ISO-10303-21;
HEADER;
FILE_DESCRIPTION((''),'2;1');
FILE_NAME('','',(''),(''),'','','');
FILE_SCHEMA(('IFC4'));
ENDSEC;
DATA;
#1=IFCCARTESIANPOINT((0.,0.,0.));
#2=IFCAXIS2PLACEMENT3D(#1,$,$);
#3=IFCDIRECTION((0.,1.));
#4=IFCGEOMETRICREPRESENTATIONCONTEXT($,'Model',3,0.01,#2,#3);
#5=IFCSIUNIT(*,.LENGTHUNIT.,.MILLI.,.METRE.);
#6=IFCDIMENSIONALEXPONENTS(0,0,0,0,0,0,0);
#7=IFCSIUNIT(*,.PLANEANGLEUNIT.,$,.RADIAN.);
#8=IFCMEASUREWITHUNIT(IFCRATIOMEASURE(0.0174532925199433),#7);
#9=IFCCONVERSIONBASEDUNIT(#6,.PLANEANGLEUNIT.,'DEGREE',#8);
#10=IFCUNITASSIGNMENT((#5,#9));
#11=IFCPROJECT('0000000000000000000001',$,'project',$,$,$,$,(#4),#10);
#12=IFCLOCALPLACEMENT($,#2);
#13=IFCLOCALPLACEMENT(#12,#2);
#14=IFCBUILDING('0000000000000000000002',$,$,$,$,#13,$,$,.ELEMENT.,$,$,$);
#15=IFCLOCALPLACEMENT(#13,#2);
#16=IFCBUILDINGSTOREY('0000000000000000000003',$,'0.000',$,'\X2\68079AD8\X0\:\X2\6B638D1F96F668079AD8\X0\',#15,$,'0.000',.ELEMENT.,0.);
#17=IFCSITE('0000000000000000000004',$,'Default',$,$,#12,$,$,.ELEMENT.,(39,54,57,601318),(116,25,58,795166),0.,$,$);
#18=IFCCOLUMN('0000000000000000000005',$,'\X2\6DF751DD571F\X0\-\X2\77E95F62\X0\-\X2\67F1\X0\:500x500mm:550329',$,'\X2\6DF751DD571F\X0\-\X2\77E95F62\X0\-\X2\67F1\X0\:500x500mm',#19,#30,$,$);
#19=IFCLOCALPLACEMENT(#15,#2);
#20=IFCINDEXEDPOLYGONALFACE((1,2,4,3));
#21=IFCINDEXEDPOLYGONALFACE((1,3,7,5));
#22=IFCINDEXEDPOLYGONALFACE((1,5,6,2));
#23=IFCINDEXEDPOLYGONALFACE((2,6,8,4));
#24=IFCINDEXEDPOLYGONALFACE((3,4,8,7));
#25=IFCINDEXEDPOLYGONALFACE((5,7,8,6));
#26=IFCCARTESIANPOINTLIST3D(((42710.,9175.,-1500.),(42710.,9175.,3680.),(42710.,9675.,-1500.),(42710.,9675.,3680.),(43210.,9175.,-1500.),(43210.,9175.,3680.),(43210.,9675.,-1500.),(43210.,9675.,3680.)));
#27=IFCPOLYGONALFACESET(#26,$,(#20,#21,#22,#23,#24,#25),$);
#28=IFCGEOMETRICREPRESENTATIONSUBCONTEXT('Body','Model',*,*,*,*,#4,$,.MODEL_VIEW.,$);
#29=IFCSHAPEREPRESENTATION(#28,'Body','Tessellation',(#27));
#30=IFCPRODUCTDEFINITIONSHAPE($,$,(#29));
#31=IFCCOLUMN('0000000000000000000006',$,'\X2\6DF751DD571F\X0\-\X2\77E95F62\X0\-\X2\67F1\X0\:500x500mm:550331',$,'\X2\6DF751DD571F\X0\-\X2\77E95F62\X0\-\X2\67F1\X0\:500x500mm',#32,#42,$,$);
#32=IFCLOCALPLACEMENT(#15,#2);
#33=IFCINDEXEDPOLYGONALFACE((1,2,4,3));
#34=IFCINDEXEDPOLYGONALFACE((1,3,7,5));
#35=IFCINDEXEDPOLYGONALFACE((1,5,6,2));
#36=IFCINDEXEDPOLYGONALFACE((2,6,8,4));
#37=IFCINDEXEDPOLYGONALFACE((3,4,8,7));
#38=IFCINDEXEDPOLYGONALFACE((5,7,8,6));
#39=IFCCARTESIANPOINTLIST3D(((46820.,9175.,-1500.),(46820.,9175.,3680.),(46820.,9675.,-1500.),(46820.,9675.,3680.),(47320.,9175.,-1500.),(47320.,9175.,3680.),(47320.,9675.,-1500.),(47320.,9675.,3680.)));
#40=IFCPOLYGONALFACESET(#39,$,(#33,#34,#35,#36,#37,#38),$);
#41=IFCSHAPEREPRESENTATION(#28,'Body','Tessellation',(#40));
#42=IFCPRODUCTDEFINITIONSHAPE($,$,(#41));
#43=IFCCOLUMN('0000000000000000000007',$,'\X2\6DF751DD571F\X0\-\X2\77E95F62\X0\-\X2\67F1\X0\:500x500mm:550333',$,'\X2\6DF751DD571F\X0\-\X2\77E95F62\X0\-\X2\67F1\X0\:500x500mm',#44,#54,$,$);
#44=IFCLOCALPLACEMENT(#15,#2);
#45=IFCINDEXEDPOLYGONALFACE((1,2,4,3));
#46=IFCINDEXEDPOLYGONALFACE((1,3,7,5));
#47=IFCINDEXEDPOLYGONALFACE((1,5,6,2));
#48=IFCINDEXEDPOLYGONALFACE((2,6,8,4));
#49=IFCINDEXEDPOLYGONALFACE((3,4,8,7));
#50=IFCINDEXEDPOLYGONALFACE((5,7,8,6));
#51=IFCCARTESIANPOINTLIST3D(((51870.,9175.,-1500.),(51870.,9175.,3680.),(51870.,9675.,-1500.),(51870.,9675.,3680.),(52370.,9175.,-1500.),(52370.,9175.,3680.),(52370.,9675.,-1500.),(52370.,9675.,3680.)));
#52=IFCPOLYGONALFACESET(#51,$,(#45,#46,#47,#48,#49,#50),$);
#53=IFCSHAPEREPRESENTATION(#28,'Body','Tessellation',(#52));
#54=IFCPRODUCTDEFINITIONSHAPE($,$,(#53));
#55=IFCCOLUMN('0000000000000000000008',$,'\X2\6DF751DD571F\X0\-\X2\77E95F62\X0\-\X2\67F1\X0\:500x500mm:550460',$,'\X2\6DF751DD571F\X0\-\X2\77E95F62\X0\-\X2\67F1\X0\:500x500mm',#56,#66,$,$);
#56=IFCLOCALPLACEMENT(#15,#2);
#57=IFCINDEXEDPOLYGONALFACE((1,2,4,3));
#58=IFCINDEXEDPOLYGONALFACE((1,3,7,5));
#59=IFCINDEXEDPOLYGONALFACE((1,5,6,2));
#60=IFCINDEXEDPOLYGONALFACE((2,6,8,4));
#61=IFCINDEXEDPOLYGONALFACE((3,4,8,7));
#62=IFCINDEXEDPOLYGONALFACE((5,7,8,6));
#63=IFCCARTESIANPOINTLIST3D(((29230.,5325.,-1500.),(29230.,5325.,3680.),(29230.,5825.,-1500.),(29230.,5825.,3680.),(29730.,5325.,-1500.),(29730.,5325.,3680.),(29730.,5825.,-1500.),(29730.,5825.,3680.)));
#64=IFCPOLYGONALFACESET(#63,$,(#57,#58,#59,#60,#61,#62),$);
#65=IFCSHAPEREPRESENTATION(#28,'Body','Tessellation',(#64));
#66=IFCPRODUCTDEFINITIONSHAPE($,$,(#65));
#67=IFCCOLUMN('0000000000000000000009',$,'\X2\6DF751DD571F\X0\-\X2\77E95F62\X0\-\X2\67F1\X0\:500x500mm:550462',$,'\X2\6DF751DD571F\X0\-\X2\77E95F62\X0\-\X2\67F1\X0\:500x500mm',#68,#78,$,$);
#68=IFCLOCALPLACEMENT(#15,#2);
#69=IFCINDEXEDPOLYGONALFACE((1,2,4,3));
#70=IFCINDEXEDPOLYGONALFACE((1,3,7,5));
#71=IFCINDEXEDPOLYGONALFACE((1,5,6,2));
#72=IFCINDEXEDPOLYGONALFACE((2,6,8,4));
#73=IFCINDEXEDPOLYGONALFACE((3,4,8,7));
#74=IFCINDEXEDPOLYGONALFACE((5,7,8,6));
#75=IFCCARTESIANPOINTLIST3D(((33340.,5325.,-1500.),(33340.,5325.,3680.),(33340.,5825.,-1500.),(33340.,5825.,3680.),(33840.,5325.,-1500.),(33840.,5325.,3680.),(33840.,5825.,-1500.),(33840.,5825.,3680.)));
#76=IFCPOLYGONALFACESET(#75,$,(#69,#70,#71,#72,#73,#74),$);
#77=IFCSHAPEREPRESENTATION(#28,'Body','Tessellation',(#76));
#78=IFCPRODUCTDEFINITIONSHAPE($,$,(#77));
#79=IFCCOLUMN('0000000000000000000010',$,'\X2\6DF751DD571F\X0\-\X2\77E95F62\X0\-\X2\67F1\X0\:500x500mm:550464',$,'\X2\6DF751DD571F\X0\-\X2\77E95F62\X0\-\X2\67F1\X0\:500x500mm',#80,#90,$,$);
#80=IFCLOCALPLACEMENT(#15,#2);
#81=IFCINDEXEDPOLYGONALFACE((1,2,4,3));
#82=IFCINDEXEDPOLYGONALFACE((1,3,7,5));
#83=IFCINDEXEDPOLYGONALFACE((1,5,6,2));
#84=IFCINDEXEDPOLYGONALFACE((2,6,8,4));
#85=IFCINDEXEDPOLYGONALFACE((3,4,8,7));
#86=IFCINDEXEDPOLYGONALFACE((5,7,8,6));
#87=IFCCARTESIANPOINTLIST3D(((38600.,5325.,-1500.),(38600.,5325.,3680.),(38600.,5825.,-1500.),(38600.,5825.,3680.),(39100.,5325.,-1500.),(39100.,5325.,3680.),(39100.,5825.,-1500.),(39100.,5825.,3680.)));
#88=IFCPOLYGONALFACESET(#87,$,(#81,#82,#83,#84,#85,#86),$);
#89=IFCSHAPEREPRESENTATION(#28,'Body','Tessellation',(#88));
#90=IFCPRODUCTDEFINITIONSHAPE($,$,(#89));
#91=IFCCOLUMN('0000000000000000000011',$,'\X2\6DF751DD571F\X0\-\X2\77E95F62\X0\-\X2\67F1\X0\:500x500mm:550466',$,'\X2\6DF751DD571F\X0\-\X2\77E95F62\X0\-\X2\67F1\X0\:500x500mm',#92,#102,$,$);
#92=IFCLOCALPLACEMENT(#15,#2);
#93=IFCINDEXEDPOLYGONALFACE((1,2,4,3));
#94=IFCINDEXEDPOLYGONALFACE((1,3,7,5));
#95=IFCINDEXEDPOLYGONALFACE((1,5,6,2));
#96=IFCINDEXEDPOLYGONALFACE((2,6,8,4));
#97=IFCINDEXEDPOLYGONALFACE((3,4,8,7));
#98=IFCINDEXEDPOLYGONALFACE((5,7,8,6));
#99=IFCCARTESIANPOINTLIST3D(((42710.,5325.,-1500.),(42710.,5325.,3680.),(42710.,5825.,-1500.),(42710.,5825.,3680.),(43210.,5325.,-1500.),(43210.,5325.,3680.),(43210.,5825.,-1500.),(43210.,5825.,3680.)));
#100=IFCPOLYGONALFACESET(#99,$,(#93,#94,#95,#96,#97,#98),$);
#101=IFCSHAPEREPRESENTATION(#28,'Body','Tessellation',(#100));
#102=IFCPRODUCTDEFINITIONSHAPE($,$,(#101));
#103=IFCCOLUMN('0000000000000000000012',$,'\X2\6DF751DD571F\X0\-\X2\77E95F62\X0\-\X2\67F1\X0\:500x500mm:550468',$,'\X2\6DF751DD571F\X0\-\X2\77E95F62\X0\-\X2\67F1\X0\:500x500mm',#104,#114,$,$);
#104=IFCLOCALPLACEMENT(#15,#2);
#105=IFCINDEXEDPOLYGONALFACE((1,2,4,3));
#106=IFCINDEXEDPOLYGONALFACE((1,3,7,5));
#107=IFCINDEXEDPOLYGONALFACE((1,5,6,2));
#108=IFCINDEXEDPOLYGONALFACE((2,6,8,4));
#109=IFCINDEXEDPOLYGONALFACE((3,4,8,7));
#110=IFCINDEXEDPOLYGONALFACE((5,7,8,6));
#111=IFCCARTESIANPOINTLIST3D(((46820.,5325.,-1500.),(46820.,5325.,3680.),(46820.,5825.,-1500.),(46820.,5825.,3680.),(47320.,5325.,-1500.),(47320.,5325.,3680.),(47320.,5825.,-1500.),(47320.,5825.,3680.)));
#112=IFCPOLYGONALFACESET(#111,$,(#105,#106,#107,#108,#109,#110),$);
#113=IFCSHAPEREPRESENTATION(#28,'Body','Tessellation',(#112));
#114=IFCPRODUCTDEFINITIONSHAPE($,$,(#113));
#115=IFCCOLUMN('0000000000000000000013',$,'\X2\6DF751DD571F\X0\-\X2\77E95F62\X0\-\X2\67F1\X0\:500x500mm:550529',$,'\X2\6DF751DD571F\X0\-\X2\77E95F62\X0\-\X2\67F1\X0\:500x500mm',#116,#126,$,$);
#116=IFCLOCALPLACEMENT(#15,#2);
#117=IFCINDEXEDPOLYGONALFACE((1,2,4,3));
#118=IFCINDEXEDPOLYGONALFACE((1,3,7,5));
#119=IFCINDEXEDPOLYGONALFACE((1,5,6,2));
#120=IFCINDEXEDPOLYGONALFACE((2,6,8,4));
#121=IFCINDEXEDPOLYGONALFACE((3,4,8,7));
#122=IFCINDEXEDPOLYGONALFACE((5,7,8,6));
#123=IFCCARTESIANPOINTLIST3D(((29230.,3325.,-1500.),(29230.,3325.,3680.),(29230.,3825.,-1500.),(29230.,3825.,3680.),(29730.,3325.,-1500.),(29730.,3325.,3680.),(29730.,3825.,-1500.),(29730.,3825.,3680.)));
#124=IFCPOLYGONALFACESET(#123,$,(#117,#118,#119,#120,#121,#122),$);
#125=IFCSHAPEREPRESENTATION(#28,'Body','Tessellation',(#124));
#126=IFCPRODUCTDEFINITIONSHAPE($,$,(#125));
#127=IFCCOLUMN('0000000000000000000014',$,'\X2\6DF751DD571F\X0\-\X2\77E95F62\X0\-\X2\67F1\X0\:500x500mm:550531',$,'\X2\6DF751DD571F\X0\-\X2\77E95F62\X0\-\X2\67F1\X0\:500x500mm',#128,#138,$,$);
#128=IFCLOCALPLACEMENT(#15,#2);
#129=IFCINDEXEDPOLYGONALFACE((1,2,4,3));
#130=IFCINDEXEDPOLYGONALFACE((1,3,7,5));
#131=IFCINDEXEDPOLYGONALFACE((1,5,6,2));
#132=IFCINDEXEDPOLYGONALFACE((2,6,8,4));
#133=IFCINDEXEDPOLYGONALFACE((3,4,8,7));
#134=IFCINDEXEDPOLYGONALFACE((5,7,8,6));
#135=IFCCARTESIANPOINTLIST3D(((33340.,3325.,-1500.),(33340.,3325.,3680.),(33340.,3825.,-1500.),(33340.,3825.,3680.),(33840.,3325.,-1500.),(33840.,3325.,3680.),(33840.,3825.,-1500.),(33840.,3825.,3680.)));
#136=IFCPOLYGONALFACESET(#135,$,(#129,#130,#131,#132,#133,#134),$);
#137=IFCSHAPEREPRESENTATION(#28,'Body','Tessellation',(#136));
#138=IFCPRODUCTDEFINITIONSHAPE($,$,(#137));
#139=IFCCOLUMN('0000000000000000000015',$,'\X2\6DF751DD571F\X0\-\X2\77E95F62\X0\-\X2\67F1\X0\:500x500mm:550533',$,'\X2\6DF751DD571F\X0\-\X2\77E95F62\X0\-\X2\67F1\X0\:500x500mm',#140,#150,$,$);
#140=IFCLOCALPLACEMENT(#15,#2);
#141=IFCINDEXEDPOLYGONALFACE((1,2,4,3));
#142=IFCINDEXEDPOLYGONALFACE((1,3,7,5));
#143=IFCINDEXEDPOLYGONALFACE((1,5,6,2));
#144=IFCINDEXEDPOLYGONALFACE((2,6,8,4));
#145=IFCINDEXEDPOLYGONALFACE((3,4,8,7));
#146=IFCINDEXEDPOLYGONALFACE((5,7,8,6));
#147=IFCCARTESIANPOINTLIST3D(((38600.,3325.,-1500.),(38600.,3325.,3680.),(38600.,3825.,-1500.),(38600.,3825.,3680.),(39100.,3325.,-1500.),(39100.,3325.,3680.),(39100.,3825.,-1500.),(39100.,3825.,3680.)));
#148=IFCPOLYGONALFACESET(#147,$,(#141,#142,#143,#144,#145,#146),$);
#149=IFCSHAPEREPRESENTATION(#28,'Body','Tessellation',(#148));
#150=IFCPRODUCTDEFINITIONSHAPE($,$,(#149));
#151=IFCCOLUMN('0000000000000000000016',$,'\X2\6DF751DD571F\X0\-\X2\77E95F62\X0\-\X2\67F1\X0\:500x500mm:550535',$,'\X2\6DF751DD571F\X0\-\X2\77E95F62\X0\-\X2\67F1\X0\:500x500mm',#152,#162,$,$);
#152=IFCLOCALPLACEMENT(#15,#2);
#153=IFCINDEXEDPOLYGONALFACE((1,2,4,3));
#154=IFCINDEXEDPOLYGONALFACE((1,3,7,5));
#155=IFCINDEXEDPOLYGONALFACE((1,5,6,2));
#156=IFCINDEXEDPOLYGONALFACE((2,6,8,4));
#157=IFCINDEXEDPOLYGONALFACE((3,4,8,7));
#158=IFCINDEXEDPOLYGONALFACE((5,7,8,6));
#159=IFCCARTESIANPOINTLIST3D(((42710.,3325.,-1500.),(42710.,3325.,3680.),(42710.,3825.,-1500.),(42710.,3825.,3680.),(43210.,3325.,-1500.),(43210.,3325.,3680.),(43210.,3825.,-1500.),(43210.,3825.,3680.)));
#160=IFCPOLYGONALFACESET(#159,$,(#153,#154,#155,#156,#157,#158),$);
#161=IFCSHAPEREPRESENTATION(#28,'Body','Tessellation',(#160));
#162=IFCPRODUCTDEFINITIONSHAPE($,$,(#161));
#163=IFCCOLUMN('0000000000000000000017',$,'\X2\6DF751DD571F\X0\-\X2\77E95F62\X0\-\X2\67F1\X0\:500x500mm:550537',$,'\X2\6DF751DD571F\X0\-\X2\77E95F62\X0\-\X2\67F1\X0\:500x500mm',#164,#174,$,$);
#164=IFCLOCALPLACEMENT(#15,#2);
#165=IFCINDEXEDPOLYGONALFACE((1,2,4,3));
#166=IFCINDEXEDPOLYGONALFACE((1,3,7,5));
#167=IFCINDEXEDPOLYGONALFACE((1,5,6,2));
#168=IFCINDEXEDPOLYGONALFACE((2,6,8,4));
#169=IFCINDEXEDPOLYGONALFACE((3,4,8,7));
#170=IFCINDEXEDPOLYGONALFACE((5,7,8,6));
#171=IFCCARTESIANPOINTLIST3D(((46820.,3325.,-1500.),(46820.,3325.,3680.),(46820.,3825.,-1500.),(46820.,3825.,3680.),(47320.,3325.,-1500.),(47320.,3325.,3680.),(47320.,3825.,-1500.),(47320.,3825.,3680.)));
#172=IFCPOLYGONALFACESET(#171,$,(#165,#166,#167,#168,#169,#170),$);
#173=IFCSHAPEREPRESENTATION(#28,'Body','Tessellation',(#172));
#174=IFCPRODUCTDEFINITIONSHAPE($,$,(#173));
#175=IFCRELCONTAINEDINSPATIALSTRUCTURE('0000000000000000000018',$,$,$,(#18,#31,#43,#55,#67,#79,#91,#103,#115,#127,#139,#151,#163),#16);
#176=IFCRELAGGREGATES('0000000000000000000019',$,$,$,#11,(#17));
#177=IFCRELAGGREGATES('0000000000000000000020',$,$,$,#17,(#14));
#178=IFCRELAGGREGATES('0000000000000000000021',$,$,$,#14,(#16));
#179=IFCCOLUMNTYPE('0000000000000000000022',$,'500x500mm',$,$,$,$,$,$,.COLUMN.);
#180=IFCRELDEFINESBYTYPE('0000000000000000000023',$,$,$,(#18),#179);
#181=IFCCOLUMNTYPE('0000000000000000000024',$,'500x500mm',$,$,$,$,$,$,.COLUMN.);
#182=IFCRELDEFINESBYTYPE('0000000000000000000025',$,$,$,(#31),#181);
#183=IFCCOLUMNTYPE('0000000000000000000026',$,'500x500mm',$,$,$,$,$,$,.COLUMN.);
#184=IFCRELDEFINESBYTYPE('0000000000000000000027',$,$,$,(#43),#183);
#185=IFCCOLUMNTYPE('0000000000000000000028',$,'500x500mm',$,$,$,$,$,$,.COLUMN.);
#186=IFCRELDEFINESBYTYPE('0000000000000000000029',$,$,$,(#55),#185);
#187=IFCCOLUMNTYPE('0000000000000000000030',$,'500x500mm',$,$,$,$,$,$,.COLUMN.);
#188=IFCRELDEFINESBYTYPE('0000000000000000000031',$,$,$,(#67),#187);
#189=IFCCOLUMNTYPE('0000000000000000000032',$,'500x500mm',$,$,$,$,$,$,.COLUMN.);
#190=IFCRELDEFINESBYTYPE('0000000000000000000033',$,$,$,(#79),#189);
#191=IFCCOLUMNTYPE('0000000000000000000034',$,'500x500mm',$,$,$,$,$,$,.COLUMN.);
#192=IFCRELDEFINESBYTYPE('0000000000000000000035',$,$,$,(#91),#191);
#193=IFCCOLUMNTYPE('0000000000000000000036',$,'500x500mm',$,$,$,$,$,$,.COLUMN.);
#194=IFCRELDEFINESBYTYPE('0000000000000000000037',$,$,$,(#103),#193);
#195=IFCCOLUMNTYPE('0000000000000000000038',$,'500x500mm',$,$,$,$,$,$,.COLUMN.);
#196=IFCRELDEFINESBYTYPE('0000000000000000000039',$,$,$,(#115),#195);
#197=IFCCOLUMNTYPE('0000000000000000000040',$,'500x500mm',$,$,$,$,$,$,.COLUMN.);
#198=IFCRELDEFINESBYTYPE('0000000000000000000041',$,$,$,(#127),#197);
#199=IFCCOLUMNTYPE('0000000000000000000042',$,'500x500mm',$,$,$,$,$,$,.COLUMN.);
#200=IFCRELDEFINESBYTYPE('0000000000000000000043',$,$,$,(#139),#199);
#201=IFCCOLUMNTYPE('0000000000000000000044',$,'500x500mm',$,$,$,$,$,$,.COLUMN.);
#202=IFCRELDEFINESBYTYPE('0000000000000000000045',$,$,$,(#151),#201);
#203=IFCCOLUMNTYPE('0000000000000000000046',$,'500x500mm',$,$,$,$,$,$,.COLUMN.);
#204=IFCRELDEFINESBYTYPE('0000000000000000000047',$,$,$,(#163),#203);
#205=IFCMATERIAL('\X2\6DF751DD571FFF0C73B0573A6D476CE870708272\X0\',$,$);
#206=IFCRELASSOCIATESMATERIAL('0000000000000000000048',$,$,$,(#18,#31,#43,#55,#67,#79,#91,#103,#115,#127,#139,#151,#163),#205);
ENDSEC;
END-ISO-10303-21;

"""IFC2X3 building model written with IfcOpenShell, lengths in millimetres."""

from ifc_helpers import new_model, entity, si_unit, converted_unit, direction, frame, frame_2d, origin, origin_2d_with_axis, place, context, subcontext, project, spatial, rectangle, extrude, source, transform, mapped, material, type_object, type_shapes, element, save


model = new_model("IFC2X3")

# Units and contexts
model_context = context("Model", 3, precision=0.01, world=origin(), true_north=direction((0.0, 1.0)))
body_context = subcontext(model_context, "Body", "Model", "MODEL_VIEW")
ifc_project = project(units=[si_unit("LENGTHUNIT", "METRE", prefix="MILLI"), converted_unit("PLANEANGLEUNIT", "DEGREE", entity("IfcRatioMeasure", 0.0174532925199433), si_unit("PLANEANGLEUNIT", "RADIAN"), dimensions=[0, 0, 0, 0, 0, 0, 0])], contexts=[model_context])

# Site, building, storey
site_placement = place(None, origin())
site = spatial("IfcSite", under=ifc_project, at=site_placement, Name="Default", CompositionType="ELEMENT", RefLatitude=(39, 54, 57, 601318), RefLongitude=(116, 25, 58, 795166), RefElevation=0.0)
building_placement = place(site_placement, origin())
building = spatial("IfcBuilding", under=site, at=building_placement, CompositionType="ELEMENT")
storey_placement = place(building_placement, origin())
storey = spatial("IfcBuildingStorey", under=building, at=storey_placement, Name="0.000", ObjectType="标高:正负零标高", LongName="0.000", CompositionType="ELEMENT", Elevation=0.0)

# Columns
ifc_material_1 = material(Name="混凝土，现场浇注灰色")
column_type_1 = type_object("IfcColumnType", Name="500x500mm", PredefinedType="COLUMN")
shared_shape_1 = source(origin(), body_context, "Body", "SweptSolid", [
    extrude(rectangle(XDim=500.0, YDim=500.0, at=origin_2d_with_axis()), frame((42960.0, 9425.0, -1500.0), z_axis=(0.0, 0.0, 1.0), x_axis=(0.0, -1.0, 0.0)), (0.0, 0.0, 1.0), 5180.0),
])
type_shapes(column_type_1, [shared_shape_1])
column_1_placement = place(storey_placement, origin())
element("IfcColumn", 1, at=column_1_placement, inside=storey, type_object=column_type_1, material=ifc_material_1, Name="混凝土-矩形-柱:500x500mm:550329", ObjectType="混凝土-矩形-柱:500x500mm", context=body_context, shape_type="MappedRepresentation", body=[
    mapped(shared_shape_1, transform((0.0, 0.0, 0.0), scale=1.0)),
])
column_type_2 = type_object("IfcColumnType", Name="500x500mm", PredefinedType="COLUMN")
shared_shape_2 = source(origin(), body_context, "Body", "SweptSolid", [
    extrude(rectangle(XDim=500.0, YDim=500.0, at=origin_2d_with_axis()), frame((47070.0, 9425.0, -1500.0), z_axis=(0.0, 0.0, 1.0), x_axis=(0.0, -1.0, 0.0)), (0.0, 0.0, 1.0), 5180.0),
])
type_shapes(column_type_2, [shared_shape_2])
column_2_placement = place(storey_placement, origin())
element("IfcColumn", 2, at=column_2_placement, inside=storey, type_object=column_type_2, material=ifc_material_1, Name="混凝土-矩形-柱:500x500mm:550331", ObjectType="混凝土-矩形-柱:500x500mm", context=body_context, shape_type="MappedRepresentation", body=[
    mapped(shared_shape_2, transform((0.0, 0.0, 0.0), scale=1.0)),
])
column_type_3 = type_object("IfcColumnType", Name="500x500mm", PredefinedType="COLUMN")
shared_shape_3 = source(origin(), body_context, "Body", "SweptSolid", [
    extrude(rectangle(XDim=500.0, YDim=500.0, at=frame_2d((0.0, 0.0), x_axis=(1.0, 0.0))), frame((52120.0, 9425.0, -1500.0), z_axis=(0.0, 0.0, 1.0), x_axis=(0.0, -1.0, 0.0)), (0.0, 0.0, 1.0), 5180.0),
])
type_shapes(column_type_3, [shared_shape_3])
column_3_placement = place(storey_placement, origin())
element("IfcColumn", 3, at=column_3_placement, inside=storey, type_object=column_type_3, material=ifc_material_1, Name="混凝土-矩形-柱:500x500mm:550333", ObjectType="混凝土-矩形-柱:500x500mm", context=body_context, shape_type="MappedRepresentation", body=[
    mapped(shared_shape_3, transform((0.0, 0.0, 0.0), scale=1.0)),
])
column_type_4 = type_object("IfcColumnType", Name="500x500mm", PredefinedType="COLUMN")
shared_shape_4 = source(origin(), body_context, "Body", "SweptSolid", [
    extrude(rectangle(XDim=500.0, YDim=500.0, at=origin_2d_with_axis()), frame((29480.0, 5575.0, -1500.0), z_axis=(0.0, 0.0, 1.0), x_axis=(0.0, -1.0, 0.0)), (0.0, 0.0, 1.0), 5180.0),
])
type_shapes(column_type_4, [shared_shape_4])
column_4_placement = place(storey_placement, origin())
element("IfcColumn", 4, at=column_4_placement, inside=storey, type_object=column_type_4, material=ifc_material_1, Name="混凝土-矩形-柱:500x500mm:550460", ObjectType="混凝土-矩形-柱:500x500mm", context=body_context, shape_type="MappedRepresentation", body=[
    mapped(shared_shape_4, transform((0.0, 0.0, 0.0), scale=1.0)),
])
column_type_5 = type_object("IfcColumnType", Name="500x500mm", PredefinedType="COLUMN")
shared_shape_5 = source(origin(), body_context, "Body", "SweptSolid", [
    extrude(rectangle(XDim=500.0, YDim=500.0, at=origin_2d_with_axis()), frame((33590.0, 5575.0, -1500.0), z_axis=(0.0, 0.0, 1.0), x_axis=(0.0, -1.0, 0.0)), (0.0, 0.0, 1.0), 5180.0),
])
type_shapes(column_type_5, [shared_shape_5])
column_5_placement = place(storey_placement, origin())
element("IfcColumn", 5, at=column_5_placement, inside=storey, type_object=column_type_5, material=ifc_material_1, Name="混凝土-矩形-柱:500x500mm:550462", ObjectType="混凝土-矩形-柱:500x500mm", context=body_context, shape_type="MappedRepresentation", body=[
    mapped(shared_shape_5, transform((0.0, 0.0, 0.0), scale=1.0)),
])
column_type_6 = type_object("IfcColumnType", Name="500x500mm", PredefinedType="COLUMN")
shared_shape_6 = source(origin(), body_context, "Body", "SweptSolid", [
    extrude(rectangle(XDim=500.0, YDim=500.0, at=frame_2d((0.0, 0.0), x_axis=(1.0, 0.0))), frame((38850.0, 5575.0, -1500.0), z_axis=(0.0, 0.0, 1.0), x_axis=(0.0, -1.0, 0.0)), (0.0, 0.0, 1.0), 5180.0),
])
type_shapes(column_type_6, [shared_shape_6])
column_6_placement = place(storey_placement, origin())
element("IfcColumn", 6, at=column_6_placement, inside=storey, type_object=column_type_6, material=ifc_material_1, Name="混凝土-矩形-柱:500x500mm:550464", ObjectType="混凝土-矩形-柱:500x500mm", context=body_context, shape_type="MappedRepresentation", body=[
    mapped(shared_shape_6, transform((0.0, 0.0, 0.0), scale=1.0)),
])
column_type_7 = type_object("IfcColumnType", Name="500x500mm", PredefinedType="COLUMN")
shared_shape_7 = source(origin(), body_context, "Body", "SweptSolid", [
    extrude(rectangle(XDim=500.0, YDim=500.0, at=origin_2d_with_axis()), frame((42960.0, 5575.0, -1500.0), z_axis=(0.0, 0.0, 1.0), x_axis=(0.0, -1.0, 0.0)), (0.0, 0.0, 1.0), 5180.0),
])
type_shapes(column_type_7, [shared_shape_7])
column_7_placement = place(storey_placement, origin())
element("IfcColumn", 7, at=column_7_placement, inside=storey, type_object=column_type_7, material=ifc_material_1, Name="混凝土-矩形-柱:500x500mm:550466", ObjectType="混凝土-矩形-柱:500x500mm", context=body_context, shape_type="MappedRepresentation", body=[
    mapped(shared_shape_7, transform((0.0, 0.0, 0.0), scale=1.0)),
])
column_type_8 = type_object("IfcColumnType", Name="500x500mm", PredefinedType="COLUMN")
shared_shape_8 = source(origin(), body_context, "Body", "SweptSolid", [
    extrude(rectangle(XDim=500.0, YDim=500.0, at=origin_2d_with_axis()), frame((47070.0, 5575.0, -1500.0), z_axis=(0.0, 0.0, 1.0), x_axis=(0.0, -1.0, 0.0)), (0.0, 0.0, 1.0), 5180.0),
])
type_shapes(column_type_8, [shared_shape_8])
column_8_placement = place(storey_placement, origin())
element("IfcColumn", 8, at=column_8_placement, inside=storey, type_object=column_type_8, material=ifc_material_1, Name="混凝土-矩形-柱:500x500mm:550468", ObjectType="混凝土-矩形-柱:500x500mm", context=body_context, shape_type="MappedRepresentation", body=[
    mapped(shared_shape_8, transform((0.0, 0.0, 0.0), scale=1.0)),
])
column_type_9 = type_object("IfcColumnType", Name="500x500mm", PredefinedType="COLUMN")
shared_shape_9 = source(origin(), body_context, "Body", "SweptSolid", [
    extrude(rectangle(XDim=500.0, YDim=500.0, at=origin_2d_with_axis()), frame((29480.0, 3575.0, -1500.0), z_axis=(0.0, 0.0, 1.0), x_axis=(0.0, -1.0, 0.0)), (0.0, 0.0, 1.0), 5180.0),
])
type_shapes(column_type_9, [shared_shape_9])
column_9_placement = place(storey_placement, origin())
element("IfcColumn", 9, at=column_9_placement, inside=storey, type_object=column_type_9, material=ifc_material_1, Name="混凝土-矩形-柱:500x500mm:550529", ObjectType="混凝土-矩形-柱:500x500mm", context=body_context, shape_type="MappedRepresentation", body=[
    mapped(shared_shape_9, transform((0.0, 0.0, 0.0), scale=1.0)),
])
column_type_10 = type_object("IfcColumnType", Name="500x500mm", PredefinedType="COLUMN")
shared_shape_10 = source(origin(), body_context, "Body", "SweptSolid", [
    extrude(rectangle(XDim=500.0, YDim=500.0, at=origin_2d_with_axis()), frame((33590.0, 3575.0, -1500.0), z_axis=(0.0, 0.0, 1.0), x_axis=(0.0, -1.0, 0.0)), (0.0, 0.0, 1.0), 5180.0),
])
type_shapes(column_type_10, [shared_shape_10])
column_10_placement = place(storey_placement, origin())
element("IfcColumn", 10, at=column_10_placement, inside=storey, type_object=column_type_10, material=ifc_material_1, Name="混凝土-矩形-柱:500x500mm:550531", ObjectType="混凝土-矩形-柱:500x500mm", context=body_context, shape_type="MappedRepresentation", body=[
    mapped(shared_shape_10, transform((0.0, 0.0, 0.0), scale=1.0)),
])
column_type_11 = type_object("IfcColumnType", Name="500x500mm", PredefinedType="COLUMN")
shared_shape_11 = source(origin(), body_context, "Body", "SweptSolid", [
    extrude(rectangle(XDim=500.0, YDim=500.0, at=frame_2d((0.0, 0.0), x_axis=(1.0, 0.0))), frame((38850.0, 3575.0, -1500.0), z_axis=(0.0, 0.0, 1.0), x_axis=(0.0, -1.0, 0.0)), (0.0, 0.0, 1.0), 5180.0),
])
type_shapes(column_type_11, [shared_shape_11])
column_11_placement = place(storey_placement, origin())
element("IfcColumn", 11, at=column_11_placement, inside=storey, type_object=column_type_11, material=ifc_material_1, Name="混凝土-矩形-柱:500x500mm:550533", ObjectType="混凝土-矩形-柱:500x500mm", context=body_context, shape_type="MappedRepresentation", body=[
    mapped(shared_shape_11, transform((0.0, 0.0, 0.0), scale=1.0)),
])
column_type_12 = type_object("IfcColumnType", Name="500x500mm", PredefinedType="COLUMN")
shared_shape_12 = source(origin(), body_context, "Body", "SweptSolid", [
    extrude(rectangle(XDim=500.0, YDim=500.0, at=origin_2d_with_axis()), frame((42960.0, 3575.0, -1500.0), z_axis=(0.0, 0.0, 1.0), x_axis=(0.0, -1.0, 0.0)), (0.0, 0.0, 1.0), 5180.0),
])
type_shapes(column_type_12, [shared_shape_12])
column_12_placement = place(storey_placement, origin())
element("IfcColumn", 12, at=column_12_placement, inside=storey, type_object=column_type_12, material=ifc_material_1, Name="混凝土-矩形-柱:500x500mm:550535", ObjectType="混凝土-矩形-柱:500x500mm", context=body_context, shape_type="MappedRepresentation", body=[
    mapped(shared_shape_12, transform((0.0, 0.0, 0.0), scale=1.0)),
])
column_type_13 = type_object("IfcColumnType", Name="500x500mm", PredefinedType="COLUMN")
shared_shape_13 = source(origin(), body_context, "Body", "SweptSolid", [
    extrude(rectangle(XDim=500.0, YDim=500.0, at=origin_2d_with_axis()), frame((47070.0, 3575.0, -1500.0), z_axis=(0.0, 0.0, 1.0), x_axis=(0.0, -1.0, 0.0)), (0.0, 0.0, 1.0), 5180.0),
])
type_shapes(column_type_13, [shared_shape_13])
column_13_placement = place(storey_placement, origin())
element("IfcColumn", 13, at=column_13_placement, inside=storey, type_object=column_type_13, material=ifc_material_1, Name="混凝土-矩形-柱:500x500mm:550537", ObjectType="混凝土-矩形-柱:500x500mm", context=body_context, shape_type="MappedRepresentation", body=[
    mapped(shared_shape_13, transform((0.0, 0.0, 0.0), scale=1.0)),
])

save(model, "model.ifc")
